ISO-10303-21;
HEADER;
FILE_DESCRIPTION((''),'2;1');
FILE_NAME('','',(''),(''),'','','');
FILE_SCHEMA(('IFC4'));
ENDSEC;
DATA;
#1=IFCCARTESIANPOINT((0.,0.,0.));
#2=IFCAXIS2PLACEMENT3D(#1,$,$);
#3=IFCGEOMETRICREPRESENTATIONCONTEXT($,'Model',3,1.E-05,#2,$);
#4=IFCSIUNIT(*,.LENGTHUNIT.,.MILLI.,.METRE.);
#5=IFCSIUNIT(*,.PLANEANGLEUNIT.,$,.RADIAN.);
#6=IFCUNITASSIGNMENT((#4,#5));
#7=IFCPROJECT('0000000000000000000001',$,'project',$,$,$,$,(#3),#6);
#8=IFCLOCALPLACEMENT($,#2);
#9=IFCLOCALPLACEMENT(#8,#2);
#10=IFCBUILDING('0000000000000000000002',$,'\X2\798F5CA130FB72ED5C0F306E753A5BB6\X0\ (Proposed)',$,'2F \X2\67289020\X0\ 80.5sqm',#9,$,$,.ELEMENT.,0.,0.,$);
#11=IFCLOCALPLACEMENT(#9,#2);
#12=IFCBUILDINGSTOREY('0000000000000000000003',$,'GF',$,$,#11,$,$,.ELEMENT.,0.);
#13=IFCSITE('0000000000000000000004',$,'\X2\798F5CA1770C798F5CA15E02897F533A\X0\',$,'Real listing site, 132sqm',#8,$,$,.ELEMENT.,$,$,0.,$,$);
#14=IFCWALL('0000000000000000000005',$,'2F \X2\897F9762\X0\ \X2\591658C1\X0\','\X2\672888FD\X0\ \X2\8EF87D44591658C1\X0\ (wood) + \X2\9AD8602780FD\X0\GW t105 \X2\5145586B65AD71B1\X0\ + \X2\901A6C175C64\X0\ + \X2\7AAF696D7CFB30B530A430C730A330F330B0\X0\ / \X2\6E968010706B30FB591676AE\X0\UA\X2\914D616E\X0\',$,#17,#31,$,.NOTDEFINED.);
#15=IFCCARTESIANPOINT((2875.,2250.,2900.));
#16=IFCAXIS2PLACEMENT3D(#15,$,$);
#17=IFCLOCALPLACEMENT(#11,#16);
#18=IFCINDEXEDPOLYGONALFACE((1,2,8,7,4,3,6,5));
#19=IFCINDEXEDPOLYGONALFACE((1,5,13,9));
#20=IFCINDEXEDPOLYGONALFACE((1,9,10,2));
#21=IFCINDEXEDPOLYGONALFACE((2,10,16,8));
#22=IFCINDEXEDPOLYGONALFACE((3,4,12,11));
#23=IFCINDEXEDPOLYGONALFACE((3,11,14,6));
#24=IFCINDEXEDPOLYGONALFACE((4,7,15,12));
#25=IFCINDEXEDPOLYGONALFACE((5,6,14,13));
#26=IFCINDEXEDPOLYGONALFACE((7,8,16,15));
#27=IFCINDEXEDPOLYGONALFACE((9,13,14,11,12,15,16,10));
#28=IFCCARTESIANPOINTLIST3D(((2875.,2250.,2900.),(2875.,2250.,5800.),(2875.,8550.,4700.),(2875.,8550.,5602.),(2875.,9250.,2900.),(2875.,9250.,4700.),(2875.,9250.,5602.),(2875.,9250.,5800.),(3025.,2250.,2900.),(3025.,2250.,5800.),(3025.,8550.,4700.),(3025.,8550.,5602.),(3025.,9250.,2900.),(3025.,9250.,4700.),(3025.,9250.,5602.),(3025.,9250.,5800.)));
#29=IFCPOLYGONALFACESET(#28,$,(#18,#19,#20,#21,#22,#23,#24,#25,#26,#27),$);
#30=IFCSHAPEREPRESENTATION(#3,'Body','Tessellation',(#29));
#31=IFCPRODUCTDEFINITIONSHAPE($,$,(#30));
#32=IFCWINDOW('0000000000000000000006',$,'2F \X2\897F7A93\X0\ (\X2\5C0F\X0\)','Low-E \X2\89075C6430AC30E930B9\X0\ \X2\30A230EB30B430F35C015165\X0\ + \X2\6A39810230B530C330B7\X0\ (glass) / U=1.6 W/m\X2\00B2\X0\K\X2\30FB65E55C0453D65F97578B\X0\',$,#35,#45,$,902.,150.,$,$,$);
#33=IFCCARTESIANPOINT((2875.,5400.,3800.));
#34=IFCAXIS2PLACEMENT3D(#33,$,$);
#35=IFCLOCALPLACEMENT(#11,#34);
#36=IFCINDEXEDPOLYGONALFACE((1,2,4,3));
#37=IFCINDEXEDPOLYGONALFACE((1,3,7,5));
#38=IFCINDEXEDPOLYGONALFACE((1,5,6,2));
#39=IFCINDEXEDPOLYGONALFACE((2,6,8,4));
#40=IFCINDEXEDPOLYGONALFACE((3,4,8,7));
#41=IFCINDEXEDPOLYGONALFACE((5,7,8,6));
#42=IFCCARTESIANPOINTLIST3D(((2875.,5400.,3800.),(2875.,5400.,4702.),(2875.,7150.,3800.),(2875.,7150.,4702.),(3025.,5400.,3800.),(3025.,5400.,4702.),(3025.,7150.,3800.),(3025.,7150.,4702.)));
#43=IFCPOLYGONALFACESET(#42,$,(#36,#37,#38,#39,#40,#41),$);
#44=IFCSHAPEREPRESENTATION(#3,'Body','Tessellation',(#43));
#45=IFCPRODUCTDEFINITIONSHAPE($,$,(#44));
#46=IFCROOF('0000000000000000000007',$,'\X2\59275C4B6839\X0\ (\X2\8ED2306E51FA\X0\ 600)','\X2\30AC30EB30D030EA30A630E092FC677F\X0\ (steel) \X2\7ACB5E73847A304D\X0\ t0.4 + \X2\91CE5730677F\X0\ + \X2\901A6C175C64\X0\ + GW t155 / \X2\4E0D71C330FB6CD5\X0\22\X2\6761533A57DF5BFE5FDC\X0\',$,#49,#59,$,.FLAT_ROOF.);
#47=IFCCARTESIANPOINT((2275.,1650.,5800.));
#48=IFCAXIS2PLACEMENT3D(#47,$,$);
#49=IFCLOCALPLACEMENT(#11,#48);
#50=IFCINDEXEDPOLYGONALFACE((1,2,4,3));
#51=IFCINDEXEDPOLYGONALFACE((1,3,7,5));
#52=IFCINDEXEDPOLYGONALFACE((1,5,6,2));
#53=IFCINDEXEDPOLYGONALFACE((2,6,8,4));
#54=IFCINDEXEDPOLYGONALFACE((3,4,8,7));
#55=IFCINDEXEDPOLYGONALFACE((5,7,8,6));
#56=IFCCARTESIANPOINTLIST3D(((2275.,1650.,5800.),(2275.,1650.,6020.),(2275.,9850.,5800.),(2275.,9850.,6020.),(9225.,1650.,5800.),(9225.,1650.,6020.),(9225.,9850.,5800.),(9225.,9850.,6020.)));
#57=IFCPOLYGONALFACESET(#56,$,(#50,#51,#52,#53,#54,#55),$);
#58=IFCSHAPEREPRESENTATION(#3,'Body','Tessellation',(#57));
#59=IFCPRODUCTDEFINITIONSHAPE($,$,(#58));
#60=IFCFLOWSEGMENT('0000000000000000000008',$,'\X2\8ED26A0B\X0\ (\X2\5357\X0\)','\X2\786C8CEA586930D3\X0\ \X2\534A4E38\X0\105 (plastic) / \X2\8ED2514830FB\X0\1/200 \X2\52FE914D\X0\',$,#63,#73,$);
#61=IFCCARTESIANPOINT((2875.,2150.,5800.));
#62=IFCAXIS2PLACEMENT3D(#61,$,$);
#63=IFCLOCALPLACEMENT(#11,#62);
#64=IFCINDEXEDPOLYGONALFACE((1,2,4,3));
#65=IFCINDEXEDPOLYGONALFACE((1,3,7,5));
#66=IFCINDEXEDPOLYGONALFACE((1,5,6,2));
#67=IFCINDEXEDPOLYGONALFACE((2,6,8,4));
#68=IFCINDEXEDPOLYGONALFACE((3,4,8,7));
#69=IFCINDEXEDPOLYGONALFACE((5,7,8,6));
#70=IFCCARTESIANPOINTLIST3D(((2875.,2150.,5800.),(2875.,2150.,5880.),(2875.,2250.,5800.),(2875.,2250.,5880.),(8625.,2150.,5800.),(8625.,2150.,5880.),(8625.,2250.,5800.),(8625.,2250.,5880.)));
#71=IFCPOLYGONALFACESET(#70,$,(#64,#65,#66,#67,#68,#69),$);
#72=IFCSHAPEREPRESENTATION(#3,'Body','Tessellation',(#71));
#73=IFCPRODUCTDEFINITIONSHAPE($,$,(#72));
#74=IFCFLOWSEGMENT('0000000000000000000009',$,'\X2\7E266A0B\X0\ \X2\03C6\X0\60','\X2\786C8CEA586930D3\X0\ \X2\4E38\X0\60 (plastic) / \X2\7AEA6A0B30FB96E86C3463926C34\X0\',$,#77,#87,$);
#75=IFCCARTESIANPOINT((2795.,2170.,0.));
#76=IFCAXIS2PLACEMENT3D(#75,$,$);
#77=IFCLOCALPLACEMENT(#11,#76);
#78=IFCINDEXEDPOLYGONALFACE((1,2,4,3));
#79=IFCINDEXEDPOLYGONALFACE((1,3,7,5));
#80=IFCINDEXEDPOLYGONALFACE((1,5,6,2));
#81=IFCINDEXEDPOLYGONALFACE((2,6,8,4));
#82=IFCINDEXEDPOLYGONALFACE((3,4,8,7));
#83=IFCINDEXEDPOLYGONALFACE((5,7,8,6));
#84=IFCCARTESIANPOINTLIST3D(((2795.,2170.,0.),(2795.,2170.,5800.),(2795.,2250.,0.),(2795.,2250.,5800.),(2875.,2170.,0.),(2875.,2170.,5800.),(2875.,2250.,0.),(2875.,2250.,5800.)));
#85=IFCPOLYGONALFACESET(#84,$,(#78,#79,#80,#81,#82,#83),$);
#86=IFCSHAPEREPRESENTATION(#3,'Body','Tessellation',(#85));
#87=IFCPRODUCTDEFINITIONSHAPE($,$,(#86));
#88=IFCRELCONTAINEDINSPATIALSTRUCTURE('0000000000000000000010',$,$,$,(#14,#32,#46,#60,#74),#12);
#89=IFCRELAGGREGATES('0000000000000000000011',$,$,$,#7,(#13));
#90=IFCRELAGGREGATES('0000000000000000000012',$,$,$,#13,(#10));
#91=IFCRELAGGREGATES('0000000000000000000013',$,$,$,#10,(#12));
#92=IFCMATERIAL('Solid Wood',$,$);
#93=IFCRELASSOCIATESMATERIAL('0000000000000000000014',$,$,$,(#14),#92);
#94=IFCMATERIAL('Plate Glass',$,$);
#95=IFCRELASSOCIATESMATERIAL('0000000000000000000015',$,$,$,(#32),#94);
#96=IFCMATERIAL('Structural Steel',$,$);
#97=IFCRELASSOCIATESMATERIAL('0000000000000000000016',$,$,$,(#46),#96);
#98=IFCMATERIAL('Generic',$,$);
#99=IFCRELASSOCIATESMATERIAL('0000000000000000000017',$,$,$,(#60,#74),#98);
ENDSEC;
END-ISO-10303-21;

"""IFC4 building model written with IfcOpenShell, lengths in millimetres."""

from ifc_helpers import new_model, si_unit, frame, frame_2d, origin, place, context, project, spatial, rectangle, extrude, material, element, fill, save


model = new_model("IFC4")

# Units and contexts
model_context = context("Model", 3, precision=1e-05, world=origin())
ifc_project = project(units=[si_unit("LENGTHUNIT", "METRE", prefix="MILLI"), si_unit("PLANEANGLEUNIT", "RADIAN")], contexts=[model_context])

# Site, building, storey
site_placement = place(None, origin())
site = spatial("IfcSite", under=ifc_project, at=site_placement, Name="福岡県福岡市西区", ObjectType="Real listing site, 132sqm", CompositionType="ELEMENT", RefElevation=0.0)
building_placement = place(site_placement, origin())
building = spatial("IfcBuilding", under=site, at=building_placement, Name="福岡・狭小の町家 (Proposed)", ObjectType="2F 木造 80.5sqm", CompositionType="ELEMENT", ElevationOfRefHeight=0.0, ElevationOfTerrain=0.0)
storey_placement = place(building_placement, origin())
storey = spatial("IfcBuildingStorey", under=building, at=storey_placement, Name="GF", CompositionType="ELEMENT", Elevation=0.0)

# Shared definitions
ifc_material_1 = material(Name="Solid Wood")

# Shared definitions
ifc_material_2 = material(Name="Plate Glass")

# Wall, opening, window
wall_1_placement = place(storey_placement, frame((2875.0, 2250.0, 2900.0)))
wall_1 = element("IfcWall", 1, at=wall_1_placement, inside=storey, material=ifc_material_1, Name="2F 西面 外壁", Description="木製 軸組外壁 (wood) + 高性能GW t105 充填断熱 + 通気層 + 窯業系サイディング / 準耐火・外皮UA配慮", PredefinedType="NOTDEFINED", context=model_context, shape_type="SweptSolid", body=[
    extrude(rectangle(XDim=150.0, YDim=7000.0, at=frame_2d((75.0, 3500.0))), frame((2875.0, 2250.0, 2900.0)), (0.0, 0.0, 1.0), 2900.0),
])
opening_1_placement = place(storey_placement, frame((2875.0, 5400.0, 3800.0)))
opening_1 = element("IfcOpeningElement", 2, at=opening_1_placement, cuts=wall_1, PredefinedType="NOTDEFINED", context=model_context, shape_type="SweptSolid", body=[
    extrude(rectangle(XDim=150.0, YDim=1750.0, at=frame_2d((75.0, 875.0))), frame((2875.0, 5400.0, 3800.0)), (0.0, 0.0, 1.0), 902.0),
])
window_1_placement = place(storey_placement, frame((2875.0, 5400.0, 3800.0)))
window_1 = element("IfcWindow", 3, at=window_1_placement, inside=storey, material=ifc_material_2, Name="2F 西窓 (小)", Description="Low-E 複層ガラス アルゴン封入 + 樹脂サッシ (glass) / U=1.6 W/m²K・日射取得型", OverallHeight=902.0, OverallWidth=150.0, context=model_context, shape_type="SweptSolid", body=[
    extrude(rectangle(XDim=150.0, YDim=1750.0, at=frame_2d((75.0, 875.0))), frame((2875.0, 5400.0, 3800.0)), (0.0, 0.0, 1.0), 902.0),
])
fill(opening_1, window_1)

# Roof
ifc_material_3 = material(Name="Structural Steel")
roof_placement = place(storey_placement, frame((2275.0, 1650.0, 5800.0)))
element("IfcRoof", 4, at=roof_placement, inside=storey, material=ifc_material_3, Name="大屋根 (軒の出 600)", Description="ガルバリウム鋼板 (steel) 立平葺き t0.4 + 野地板 + 通気層 + GW t155 / 不燃・法22条区域対応", PredefinedType="FLAT_ROOF", context=model_context, shape_type="SweptSolid", body=[
    extrude(rectangle(XDim=6950.0, YDim=8200.0, at=frame_2d((3475.0, 4100.0))), frame((2275.0, 1650.0, 5800.0)), (0.0, 0.0, 1.0), 220.0),
])

# Flow segments
ifc_material_4 = material(Name="Generic")
flow_segment_1_placement = place(storey_placement, frame((2875.0, 2150.0, 5800.0)))
element("IfcFlowSegment", 5, at=flow_segment_1_placement, inside=storey, material=ifc_material_4, Name="軒樋 (南)", Description="硬質塩ビ 半丸105 (plastic) / 軒先・1/200 勾配", context=model_context, shape_type="SweptSolid", body=[
    extrude(rectangle(XDim=5750.0, YDim=100.0, at=frame_2d((2875.0, 50.0))), frame((2875.0, 2150.0, 5800.0)), (0.0, 0.0, 1.0), 80.0),
])
flow_segment_2_placement = place(storey_placement, frame((2795.0, 2170.0, 0.0)))
element("IfcFlowSegment", 6, at=flow_segment_2_placement, inside=storey, material=ifc_material_4, Name="縦樋 φ60", Description="硬質塩ビ 丸60 (plastic) / 竪樋・雨水排水", context=model_context, shape_type="SweptSolid", body=[
    extrude(rectangle(XDim=80.0, YDim=80.0, at=frame_2d((40.0, 40.0))), frame((2795.0, 2170.0, 0.0)), (0.0, 0.0, 1.0), 5800.0),
])

save(model, "model.ifc")
